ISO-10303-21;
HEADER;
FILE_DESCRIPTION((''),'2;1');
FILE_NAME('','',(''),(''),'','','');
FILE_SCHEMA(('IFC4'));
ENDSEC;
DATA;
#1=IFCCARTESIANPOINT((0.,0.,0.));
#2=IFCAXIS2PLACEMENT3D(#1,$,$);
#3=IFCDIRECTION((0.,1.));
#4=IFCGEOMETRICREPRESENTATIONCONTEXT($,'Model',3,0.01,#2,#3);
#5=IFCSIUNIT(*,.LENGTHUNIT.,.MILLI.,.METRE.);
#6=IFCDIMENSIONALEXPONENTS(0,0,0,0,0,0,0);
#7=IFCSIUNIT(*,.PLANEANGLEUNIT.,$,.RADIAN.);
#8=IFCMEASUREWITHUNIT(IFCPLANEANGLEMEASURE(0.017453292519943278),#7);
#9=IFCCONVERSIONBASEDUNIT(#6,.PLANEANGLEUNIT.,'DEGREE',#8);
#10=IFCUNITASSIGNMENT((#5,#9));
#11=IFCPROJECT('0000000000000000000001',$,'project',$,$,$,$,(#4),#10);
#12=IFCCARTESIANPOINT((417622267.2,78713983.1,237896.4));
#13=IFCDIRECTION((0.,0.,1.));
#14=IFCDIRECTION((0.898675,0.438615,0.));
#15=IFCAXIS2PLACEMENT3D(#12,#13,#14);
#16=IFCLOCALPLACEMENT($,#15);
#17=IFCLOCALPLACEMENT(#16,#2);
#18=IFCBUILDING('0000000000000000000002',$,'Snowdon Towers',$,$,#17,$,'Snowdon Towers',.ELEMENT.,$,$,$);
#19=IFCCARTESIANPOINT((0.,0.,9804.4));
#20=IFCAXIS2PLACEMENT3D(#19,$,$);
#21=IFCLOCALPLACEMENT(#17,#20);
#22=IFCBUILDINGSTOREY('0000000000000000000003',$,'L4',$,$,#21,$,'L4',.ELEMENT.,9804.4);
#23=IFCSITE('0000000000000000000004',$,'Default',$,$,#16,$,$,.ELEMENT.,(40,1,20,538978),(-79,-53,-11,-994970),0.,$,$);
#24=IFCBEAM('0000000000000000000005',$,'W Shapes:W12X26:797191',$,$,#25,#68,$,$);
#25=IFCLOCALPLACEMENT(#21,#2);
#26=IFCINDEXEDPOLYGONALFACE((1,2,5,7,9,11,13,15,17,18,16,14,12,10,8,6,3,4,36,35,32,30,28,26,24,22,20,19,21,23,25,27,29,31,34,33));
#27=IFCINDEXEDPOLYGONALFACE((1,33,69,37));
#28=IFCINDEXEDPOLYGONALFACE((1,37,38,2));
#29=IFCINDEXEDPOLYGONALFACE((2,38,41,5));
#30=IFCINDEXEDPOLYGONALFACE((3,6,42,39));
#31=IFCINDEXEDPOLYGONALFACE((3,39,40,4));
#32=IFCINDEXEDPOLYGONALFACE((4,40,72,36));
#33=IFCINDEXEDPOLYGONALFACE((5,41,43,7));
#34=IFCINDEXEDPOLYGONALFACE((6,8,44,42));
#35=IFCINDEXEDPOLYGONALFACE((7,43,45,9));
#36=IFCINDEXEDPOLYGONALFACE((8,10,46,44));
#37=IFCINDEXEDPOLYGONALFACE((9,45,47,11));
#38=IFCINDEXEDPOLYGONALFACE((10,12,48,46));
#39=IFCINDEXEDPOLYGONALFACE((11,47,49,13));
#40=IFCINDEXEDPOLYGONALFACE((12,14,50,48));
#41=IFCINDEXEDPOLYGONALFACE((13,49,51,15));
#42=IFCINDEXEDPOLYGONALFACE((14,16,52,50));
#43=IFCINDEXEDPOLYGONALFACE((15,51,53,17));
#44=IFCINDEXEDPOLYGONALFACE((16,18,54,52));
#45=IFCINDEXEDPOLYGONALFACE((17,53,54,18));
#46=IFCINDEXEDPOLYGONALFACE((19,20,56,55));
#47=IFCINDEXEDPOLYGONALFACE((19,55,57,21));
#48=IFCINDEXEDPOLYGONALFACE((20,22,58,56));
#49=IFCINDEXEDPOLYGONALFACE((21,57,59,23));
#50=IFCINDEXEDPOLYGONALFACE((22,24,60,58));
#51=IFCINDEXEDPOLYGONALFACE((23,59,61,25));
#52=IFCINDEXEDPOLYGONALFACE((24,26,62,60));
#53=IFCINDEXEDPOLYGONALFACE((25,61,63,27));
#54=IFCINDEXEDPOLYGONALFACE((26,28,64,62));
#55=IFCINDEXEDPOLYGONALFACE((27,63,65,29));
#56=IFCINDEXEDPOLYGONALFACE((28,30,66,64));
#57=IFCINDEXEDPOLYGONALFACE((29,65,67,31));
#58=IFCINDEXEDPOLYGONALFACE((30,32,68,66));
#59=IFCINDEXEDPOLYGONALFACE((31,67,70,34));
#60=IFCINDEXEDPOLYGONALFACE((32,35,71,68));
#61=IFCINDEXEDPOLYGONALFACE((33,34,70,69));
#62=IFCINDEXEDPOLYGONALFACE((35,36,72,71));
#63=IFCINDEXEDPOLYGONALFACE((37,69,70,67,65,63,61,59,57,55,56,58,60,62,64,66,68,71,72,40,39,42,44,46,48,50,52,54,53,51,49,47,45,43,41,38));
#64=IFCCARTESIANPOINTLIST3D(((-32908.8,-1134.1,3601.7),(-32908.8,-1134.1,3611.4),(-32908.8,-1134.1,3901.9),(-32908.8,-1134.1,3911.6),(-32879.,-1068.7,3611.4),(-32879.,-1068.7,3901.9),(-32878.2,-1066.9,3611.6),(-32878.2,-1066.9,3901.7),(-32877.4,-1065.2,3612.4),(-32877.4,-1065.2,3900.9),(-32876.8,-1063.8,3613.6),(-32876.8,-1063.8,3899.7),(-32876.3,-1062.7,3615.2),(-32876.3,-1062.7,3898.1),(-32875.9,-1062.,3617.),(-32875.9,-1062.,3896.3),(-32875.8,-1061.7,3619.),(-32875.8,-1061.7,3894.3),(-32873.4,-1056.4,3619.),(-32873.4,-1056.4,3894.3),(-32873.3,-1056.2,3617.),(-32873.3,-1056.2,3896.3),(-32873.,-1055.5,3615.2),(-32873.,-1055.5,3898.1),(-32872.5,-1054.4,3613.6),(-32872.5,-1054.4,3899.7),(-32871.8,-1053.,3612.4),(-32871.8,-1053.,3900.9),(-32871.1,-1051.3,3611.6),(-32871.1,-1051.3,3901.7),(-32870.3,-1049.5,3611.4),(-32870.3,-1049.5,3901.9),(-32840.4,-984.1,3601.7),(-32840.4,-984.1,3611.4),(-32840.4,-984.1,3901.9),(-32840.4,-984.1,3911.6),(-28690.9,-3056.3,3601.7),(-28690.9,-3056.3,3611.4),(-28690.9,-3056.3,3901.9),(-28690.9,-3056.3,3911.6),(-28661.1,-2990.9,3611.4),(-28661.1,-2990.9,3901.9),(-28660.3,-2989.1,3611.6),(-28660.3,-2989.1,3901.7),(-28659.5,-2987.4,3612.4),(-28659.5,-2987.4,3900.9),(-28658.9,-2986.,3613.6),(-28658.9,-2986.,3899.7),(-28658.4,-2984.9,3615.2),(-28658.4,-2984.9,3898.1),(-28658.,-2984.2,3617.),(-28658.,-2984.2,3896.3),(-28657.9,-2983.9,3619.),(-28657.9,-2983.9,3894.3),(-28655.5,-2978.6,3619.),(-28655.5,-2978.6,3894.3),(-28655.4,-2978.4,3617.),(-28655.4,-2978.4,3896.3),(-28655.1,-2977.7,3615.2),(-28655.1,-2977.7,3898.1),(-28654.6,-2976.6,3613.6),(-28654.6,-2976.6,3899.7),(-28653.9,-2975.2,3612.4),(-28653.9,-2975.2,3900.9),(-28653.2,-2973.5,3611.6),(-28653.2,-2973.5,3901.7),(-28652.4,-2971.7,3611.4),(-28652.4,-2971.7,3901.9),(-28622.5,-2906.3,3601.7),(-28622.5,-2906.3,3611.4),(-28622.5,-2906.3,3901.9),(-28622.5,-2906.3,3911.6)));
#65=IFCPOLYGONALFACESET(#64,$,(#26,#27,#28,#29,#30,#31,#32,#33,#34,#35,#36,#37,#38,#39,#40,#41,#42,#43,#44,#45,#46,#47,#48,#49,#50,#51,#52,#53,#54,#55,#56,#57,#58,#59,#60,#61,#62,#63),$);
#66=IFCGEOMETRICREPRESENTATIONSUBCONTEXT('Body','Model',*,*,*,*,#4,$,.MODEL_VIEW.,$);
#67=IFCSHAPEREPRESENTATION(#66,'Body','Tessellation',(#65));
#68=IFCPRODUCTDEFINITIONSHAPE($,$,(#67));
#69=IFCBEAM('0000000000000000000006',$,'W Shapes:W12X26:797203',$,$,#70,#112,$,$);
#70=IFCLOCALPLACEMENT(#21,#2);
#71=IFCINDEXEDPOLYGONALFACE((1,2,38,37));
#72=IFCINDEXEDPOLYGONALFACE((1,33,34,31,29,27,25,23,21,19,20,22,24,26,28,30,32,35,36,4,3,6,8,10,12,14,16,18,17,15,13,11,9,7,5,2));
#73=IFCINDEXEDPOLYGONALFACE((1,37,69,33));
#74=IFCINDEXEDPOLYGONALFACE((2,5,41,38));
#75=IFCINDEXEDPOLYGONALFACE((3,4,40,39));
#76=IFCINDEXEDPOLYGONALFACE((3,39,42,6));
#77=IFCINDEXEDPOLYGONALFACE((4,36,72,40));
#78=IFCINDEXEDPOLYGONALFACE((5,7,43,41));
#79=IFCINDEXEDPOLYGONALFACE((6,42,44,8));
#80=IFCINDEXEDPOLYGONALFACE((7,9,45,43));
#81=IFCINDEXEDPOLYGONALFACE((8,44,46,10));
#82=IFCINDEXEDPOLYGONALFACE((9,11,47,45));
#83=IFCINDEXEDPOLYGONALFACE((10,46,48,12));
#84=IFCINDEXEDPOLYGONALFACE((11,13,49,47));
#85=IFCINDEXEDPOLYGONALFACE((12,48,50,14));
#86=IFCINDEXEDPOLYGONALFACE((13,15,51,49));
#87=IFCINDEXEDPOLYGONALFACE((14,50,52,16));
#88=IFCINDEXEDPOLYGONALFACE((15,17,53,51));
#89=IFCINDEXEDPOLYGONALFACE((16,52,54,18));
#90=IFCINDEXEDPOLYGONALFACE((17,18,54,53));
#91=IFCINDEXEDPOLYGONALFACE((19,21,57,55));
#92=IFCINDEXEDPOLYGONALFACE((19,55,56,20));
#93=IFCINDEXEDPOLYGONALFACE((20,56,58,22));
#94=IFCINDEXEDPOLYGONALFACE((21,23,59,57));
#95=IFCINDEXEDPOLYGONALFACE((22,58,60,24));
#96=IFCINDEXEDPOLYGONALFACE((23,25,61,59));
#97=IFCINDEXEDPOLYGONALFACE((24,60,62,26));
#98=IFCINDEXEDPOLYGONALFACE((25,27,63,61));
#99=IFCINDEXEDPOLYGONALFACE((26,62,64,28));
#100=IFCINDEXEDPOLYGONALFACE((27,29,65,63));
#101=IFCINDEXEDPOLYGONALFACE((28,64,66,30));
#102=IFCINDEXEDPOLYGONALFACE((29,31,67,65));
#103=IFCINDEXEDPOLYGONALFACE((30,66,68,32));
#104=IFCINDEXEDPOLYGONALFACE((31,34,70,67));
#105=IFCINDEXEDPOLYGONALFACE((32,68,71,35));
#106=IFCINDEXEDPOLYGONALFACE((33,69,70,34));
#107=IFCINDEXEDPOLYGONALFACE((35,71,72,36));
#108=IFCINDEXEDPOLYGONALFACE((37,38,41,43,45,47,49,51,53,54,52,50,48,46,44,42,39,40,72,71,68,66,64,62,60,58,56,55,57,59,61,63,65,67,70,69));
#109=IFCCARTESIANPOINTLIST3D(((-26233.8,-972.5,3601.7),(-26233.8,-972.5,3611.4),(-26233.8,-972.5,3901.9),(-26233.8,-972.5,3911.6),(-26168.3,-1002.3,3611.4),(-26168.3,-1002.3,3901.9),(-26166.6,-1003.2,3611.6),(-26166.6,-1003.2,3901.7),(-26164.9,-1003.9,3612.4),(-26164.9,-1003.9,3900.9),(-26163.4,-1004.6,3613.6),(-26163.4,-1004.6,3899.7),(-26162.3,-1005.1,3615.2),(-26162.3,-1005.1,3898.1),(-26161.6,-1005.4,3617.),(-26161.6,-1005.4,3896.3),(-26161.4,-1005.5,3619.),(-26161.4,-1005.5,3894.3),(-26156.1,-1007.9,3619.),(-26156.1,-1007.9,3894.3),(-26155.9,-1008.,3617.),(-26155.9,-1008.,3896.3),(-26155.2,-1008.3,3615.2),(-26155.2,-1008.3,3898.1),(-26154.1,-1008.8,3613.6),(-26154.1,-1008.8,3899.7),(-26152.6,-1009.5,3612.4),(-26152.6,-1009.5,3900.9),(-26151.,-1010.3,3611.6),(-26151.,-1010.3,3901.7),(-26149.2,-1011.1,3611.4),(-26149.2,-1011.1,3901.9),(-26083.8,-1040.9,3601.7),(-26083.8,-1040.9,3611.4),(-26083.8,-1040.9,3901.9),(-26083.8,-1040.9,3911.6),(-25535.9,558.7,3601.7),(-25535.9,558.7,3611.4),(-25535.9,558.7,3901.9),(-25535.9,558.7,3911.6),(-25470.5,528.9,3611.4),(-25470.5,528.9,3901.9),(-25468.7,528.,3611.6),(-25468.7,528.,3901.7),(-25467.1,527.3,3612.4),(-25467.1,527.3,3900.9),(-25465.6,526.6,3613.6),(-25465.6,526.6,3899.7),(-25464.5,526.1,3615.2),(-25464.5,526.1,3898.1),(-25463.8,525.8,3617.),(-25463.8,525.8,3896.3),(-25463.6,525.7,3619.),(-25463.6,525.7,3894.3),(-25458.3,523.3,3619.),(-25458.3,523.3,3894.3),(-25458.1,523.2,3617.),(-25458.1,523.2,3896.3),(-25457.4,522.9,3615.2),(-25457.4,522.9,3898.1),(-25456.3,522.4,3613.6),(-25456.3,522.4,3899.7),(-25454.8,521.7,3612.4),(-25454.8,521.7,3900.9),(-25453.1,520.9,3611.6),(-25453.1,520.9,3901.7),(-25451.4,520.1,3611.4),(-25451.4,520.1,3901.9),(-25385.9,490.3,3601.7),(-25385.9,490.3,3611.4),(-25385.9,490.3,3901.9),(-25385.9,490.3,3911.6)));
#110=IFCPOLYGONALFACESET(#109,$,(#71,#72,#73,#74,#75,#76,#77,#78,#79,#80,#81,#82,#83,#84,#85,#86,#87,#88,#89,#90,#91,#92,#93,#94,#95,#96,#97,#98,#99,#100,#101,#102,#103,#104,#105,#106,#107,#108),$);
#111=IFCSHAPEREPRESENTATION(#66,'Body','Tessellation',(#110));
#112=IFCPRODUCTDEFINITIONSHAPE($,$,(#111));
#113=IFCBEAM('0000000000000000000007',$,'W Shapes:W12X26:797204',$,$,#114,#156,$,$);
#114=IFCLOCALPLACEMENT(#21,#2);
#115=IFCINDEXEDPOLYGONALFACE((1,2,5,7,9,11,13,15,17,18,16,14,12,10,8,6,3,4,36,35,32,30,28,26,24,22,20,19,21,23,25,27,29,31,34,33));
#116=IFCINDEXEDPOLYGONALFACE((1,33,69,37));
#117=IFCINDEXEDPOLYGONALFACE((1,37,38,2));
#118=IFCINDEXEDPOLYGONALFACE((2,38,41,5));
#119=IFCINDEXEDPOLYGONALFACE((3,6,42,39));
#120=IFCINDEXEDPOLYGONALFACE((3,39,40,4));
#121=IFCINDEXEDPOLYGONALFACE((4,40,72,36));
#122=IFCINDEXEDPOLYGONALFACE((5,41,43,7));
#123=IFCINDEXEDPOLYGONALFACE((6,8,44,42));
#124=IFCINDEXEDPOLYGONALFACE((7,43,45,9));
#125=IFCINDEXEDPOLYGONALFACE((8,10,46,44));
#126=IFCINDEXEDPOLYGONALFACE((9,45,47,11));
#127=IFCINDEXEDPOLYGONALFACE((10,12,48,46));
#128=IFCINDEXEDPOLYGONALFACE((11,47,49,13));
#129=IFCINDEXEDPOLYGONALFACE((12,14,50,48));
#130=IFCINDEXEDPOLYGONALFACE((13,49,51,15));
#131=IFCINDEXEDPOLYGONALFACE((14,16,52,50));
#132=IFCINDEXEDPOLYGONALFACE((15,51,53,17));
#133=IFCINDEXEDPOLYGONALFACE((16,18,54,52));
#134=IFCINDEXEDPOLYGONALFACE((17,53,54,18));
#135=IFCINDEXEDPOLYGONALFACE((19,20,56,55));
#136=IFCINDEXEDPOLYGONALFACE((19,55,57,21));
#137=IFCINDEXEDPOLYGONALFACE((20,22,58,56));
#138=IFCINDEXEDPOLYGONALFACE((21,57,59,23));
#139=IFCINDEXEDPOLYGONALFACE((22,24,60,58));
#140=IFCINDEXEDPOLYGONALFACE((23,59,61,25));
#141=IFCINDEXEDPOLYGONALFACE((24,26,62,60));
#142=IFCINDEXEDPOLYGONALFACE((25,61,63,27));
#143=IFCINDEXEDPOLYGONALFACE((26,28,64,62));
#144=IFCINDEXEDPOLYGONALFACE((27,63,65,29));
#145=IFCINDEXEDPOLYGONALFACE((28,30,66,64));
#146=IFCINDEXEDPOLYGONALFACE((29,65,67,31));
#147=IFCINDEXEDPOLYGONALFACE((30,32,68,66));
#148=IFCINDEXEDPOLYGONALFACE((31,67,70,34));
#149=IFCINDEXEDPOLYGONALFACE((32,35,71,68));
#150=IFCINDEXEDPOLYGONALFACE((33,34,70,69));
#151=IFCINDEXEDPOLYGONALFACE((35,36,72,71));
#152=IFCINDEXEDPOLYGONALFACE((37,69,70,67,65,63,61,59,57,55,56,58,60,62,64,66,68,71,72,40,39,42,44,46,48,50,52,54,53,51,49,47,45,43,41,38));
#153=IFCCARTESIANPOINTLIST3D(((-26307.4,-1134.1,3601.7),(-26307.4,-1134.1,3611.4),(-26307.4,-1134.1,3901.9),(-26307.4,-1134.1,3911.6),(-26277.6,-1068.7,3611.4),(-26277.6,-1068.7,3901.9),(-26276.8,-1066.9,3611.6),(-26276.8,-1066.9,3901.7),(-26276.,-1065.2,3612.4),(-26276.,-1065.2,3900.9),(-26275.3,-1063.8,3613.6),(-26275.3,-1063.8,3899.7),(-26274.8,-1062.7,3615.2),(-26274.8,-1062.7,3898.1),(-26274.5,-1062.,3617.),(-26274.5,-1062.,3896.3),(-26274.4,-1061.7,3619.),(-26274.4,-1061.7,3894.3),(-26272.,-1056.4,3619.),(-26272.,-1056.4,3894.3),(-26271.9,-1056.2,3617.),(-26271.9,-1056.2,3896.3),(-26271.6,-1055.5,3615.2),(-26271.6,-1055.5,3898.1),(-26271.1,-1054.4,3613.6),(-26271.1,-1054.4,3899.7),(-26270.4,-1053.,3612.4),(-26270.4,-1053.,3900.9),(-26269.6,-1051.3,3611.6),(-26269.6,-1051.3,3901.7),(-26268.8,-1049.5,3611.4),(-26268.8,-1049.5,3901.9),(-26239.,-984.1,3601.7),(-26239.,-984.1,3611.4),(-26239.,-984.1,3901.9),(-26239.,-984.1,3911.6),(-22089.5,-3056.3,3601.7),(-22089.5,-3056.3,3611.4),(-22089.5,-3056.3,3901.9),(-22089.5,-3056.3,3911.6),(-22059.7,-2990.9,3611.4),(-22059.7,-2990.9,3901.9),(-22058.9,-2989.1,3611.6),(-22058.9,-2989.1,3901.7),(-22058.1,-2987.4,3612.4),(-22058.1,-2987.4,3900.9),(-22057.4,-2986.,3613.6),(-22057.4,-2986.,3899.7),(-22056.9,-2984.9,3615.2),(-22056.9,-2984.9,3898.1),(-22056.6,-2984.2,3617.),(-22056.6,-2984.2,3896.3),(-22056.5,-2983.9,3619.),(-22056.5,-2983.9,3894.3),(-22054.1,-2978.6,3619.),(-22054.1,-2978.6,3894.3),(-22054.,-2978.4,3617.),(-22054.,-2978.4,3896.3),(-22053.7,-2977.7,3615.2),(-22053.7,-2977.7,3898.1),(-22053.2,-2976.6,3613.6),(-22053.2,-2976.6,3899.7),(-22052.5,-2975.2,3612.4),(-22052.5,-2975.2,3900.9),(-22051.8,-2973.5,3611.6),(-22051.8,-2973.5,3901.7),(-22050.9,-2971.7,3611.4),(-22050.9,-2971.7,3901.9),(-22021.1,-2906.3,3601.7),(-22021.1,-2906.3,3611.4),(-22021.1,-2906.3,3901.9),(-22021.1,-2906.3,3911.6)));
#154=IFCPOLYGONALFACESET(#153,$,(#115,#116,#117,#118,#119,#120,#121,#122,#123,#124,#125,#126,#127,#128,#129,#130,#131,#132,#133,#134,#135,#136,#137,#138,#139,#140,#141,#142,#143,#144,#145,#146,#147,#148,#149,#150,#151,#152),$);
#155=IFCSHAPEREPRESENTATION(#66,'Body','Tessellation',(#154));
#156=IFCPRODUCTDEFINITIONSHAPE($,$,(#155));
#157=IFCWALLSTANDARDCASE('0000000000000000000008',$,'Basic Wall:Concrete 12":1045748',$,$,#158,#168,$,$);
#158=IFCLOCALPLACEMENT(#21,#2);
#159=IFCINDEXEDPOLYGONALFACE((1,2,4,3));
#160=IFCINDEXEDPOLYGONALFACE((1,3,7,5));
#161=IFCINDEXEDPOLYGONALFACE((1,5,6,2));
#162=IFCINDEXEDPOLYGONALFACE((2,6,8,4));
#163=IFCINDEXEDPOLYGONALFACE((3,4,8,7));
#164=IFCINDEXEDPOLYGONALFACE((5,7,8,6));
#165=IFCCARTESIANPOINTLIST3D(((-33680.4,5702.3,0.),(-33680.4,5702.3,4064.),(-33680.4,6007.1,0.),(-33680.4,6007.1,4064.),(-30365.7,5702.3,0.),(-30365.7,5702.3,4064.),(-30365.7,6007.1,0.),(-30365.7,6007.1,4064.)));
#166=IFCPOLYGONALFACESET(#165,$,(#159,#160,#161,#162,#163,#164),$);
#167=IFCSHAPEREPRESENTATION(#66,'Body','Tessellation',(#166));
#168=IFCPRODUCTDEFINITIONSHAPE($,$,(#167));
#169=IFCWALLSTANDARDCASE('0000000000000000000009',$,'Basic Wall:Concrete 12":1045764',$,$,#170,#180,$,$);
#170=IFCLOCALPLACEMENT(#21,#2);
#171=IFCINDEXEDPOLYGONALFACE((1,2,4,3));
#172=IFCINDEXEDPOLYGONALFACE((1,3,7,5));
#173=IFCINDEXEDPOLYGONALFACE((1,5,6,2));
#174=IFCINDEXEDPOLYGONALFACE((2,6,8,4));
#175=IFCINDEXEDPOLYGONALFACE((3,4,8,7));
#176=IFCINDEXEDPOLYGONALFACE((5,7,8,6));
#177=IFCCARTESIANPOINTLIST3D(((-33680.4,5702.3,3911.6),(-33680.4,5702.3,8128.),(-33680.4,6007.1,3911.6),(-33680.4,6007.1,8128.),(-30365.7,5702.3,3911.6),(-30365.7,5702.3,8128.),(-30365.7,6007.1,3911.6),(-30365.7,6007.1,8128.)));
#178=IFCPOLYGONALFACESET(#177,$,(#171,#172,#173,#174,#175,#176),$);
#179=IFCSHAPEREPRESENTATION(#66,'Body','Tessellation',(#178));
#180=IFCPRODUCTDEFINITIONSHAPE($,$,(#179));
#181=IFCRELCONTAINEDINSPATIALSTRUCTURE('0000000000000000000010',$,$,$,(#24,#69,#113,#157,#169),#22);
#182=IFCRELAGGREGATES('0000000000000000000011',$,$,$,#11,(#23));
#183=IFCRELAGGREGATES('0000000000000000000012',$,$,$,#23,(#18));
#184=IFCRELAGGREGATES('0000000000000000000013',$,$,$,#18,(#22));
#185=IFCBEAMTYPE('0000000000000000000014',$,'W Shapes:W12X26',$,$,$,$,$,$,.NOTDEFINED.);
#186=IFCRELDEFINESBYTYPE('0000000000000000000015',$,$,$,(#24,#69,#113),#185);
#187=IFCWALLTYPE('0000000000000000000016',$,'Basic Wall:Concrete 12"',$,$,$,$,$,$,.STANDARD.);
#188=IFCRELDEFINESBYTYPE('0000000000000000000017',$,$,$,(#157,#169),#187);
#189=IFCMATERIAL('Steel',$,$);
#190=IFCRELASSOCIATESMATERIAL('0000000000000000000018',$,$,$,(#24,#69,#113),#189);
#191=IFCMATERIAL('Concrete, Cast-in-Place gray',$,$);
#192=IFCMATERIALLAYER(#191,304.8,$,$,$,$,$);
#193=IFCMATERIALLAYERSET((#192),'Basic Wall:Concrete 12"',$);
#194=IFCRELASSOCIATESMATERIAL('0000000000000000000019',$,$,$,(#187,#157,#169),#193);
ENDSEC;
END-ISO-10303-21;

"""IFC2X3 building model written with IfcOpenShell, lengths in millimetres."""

from ifc_helpers import new_model, entity, si_unit, converted_unit, direction, frame, frame_2d, origin, place, context, subcontext, project, spatial, rectangle, i_section, extrude, material, layer, layer_set, layer_usage, type_object, element, save


model = new_model("IFC2X3")

# Units and contexts
model_context = context("Model", 3, precision=0.01, world=origin(), true_north=direction((0.0, 1.0)))
body_context = subcontext(model_context, "Body", "Model", "MODEL_VIEW")
ifc_project = project(units=[si_unit("LENGTHUNIT", "METRE", prefix="MILLI"), converted_unit("PLANEANGLEUNIT", "DEGREE", entity("IfcPlaneAngleMeasure", 0.017453292519943278), si_unit("PLANEANGLEUNIT", "RADIAN"), dimensions=[0, 0, 0, 0, 0, 0, 0])], contexts=[model_context])

# Site, building, storey
site_placement = place(None, frame((417622267.2, 78713983.1, 237896.4), z_axis=(0.0, 0.0, 1.0), x_axis=(0.898675, 0.438615, 0.0)))
site = spatial("IfcSite", under=ifc_project, at=site_placement, Name="Default", CompositionType="ELEMENT", RefLatitude=(40, 1, 20, 538978), RefLongitude=(-79, -53, -11, -994970), RefElevation=0.0)
building_placement = place(site_placement, origin())
building = spatial("IfcBuilding", under=site, at=building_placement, Name="Snowdon Towers", LongName="Snowdon Towers", CompositionType="ELEMENT")
storey_placement = place(building_placement, frame((0.0, 0.0, 9804.4)))
storey = spatial("IfcBuildingStorey", under=building, at=storey_placement, Name="L4", LongName="L4", CompositionType="ELEMENT", Elevation=9804.4)

# Shared definitions
ifc_material_1 = material(Name="Steel")

# Beams
beam_type_1 = type_object("IfcBeamType", Name="W Shapes:W12X26", PredefinedType="NOTDEFINED")
beam_1_placement = place(storey_placement, frame((-32799.6, -1093.3, 3911.6), z_axis=(0.0, 0.0, 1.0), x_axis=(0.909961, -0.414693, 0.0)))
element("IfcBeam", 1, at=beam_1_placement, inside=storey, type_object=beam_type_1, material=ifc_material_1, Name="W Shapes:W12X26:797191", context=body_context, shape_type="SweptSolid", body=[
    extrude(i_section(OverallWidth=164.8, OverallDepth=309.9, WebThickness=5.8, FlangeThickness=9.7, FilletRadius=7.6, at=frame_2d((0.0, 0.0), x_axis=(0.0, 1.0))), frame((-82.4, 0.0, -154.9), z_axis=(1.0, 0.0, 0.0), x_axis=(0.0, 0.0, -1.0)), (0.0, 0.0, 1.0), 4635.2),
])
beam_2_placement = place(storey_placement, frame((-26198.2, -1093.3, 3911.6), z_axis=(0.0, 0.0, 1.0), x_axis=(0.414693, 0.909961, 0.0)))
element("IfcBeam", 2, at=beam_2_placement, inside=storey, type_object=beam_type_1, material=ifc_material_1, Name="W Shapes:W12X26:797203", context=body_context, shape_type="SweptSolid", body=[
    extrude(i_section(OverallWidth=164.8, OverallDepth=309.9, WebThickness=5.8, FlangeThickness=9.7, FilletRadius=7.6, at=frame_2d((0.0, 0.0), x_axis=(0.0, 1.0))), frame((95.1, 0.0, -154.9), z_axis=(1.0, 0.0, 0.0), x_axis=(0.0, 0.0, -1.0)), (0.0, 0.0, 1.0), 1682.7),
])
beam_3_placement = place(storey_placement, frame((-26198.2, -1093.3, 3911.6), z_axis=(0.0, 0.0, 1.0), x_axis=(0.909961, -0.414693, 0.0)))
element("IfcBeam", 3, at=beam_3_placement, inside=storey, type_object=beam_type_1, material=ifc_material_1, Name="W Shapes:W12X26:797204", context=body_context, shape_type="SweptSolid", body=[
    extrude(i_section(OverallWidth=164.8, OverallDepth=309.9, WebThickness=5.8, FlangeThickness=9.7, FilletRadius=7.6, at=frame_2d((0.0, 0.0), x_axis=(0.0, 1.0))), frame((-82.4, 0.0, -154.9), z_axis=(1.0, 0.0, 0.0), x_axis=(0.0, 0.0, -1.0)), (0.0, 0.0, 1.0), 4635.2),
])

# Walls
ifc_material_2 = material(Name="Concrete, Cast-in-Place gray")
ifc_layer = layer(ifc_material_2, 304.8)
ifc_layer_set = layer_set([ifc_layer], Name="Basic Wall:Concrete 12\"")
ifc_layer_usage_1 = layer_usage(ifc_layer_set, "AXIS2", "POSITIVE", -152.4)
wall_type = type_object("IfcWallType", Name="Basic Wall:Concrete 12\"", PredefinedType="STANDARD", material=ifc_layer_set)
wall_1_placement = place(storey_placement, frame((-30365.7, 5854.7, 0.0), z_axis=(0.0, 0.0, 1.0), x_axis=(-1.0, 0.0, 0.0)))
element("IfcWallStandardCase", 4, at=wall_1_placement, inside=storey, type_object=wall_type, material=ifc_layer_usage_1, Name="Basic Wall:Concrete 12\":1045748", context=body_context, shape_type="SweptSolid", body=[
    extrude(rectangle(XDim=3314.7, YDim=304.8, at=frame_2d((1657.4, 0.0), x_axis=(-1.0, 0.0))), origin(), (0.0, 0.0, 1.0), 4064.0),
])
ifc_layer_usage_2 = layer_usage(ifc_layer_set, "AXIS2", "POSITIVE", -152.4)
wall_2_placement = place(storey_placement, frame((-30365.7, 5854.7, 3911.6), z_axis=(0.0, 0.0, 1.0), x_axis=(-1.0, 0.0, 0.0)))
element("IfcWallStandardCase", 5, at=wall_2_placement, inside=storey, type_object=wall_type, material=ifc_layer_usage_2, Name="Basic Wall:Concrete 12\":1045764", context=body_context, shape_type="SweptSolid", body=[
    extrude(rectangle(XDim=3314.7, YDim=304.8, at=frame_2d((1657.4, 0.0), x_axis=(-1.0, 0.0))), origin(), (0.0, 0.0, 1.0), 4216.4),
])

save(model, "model.ifc")
